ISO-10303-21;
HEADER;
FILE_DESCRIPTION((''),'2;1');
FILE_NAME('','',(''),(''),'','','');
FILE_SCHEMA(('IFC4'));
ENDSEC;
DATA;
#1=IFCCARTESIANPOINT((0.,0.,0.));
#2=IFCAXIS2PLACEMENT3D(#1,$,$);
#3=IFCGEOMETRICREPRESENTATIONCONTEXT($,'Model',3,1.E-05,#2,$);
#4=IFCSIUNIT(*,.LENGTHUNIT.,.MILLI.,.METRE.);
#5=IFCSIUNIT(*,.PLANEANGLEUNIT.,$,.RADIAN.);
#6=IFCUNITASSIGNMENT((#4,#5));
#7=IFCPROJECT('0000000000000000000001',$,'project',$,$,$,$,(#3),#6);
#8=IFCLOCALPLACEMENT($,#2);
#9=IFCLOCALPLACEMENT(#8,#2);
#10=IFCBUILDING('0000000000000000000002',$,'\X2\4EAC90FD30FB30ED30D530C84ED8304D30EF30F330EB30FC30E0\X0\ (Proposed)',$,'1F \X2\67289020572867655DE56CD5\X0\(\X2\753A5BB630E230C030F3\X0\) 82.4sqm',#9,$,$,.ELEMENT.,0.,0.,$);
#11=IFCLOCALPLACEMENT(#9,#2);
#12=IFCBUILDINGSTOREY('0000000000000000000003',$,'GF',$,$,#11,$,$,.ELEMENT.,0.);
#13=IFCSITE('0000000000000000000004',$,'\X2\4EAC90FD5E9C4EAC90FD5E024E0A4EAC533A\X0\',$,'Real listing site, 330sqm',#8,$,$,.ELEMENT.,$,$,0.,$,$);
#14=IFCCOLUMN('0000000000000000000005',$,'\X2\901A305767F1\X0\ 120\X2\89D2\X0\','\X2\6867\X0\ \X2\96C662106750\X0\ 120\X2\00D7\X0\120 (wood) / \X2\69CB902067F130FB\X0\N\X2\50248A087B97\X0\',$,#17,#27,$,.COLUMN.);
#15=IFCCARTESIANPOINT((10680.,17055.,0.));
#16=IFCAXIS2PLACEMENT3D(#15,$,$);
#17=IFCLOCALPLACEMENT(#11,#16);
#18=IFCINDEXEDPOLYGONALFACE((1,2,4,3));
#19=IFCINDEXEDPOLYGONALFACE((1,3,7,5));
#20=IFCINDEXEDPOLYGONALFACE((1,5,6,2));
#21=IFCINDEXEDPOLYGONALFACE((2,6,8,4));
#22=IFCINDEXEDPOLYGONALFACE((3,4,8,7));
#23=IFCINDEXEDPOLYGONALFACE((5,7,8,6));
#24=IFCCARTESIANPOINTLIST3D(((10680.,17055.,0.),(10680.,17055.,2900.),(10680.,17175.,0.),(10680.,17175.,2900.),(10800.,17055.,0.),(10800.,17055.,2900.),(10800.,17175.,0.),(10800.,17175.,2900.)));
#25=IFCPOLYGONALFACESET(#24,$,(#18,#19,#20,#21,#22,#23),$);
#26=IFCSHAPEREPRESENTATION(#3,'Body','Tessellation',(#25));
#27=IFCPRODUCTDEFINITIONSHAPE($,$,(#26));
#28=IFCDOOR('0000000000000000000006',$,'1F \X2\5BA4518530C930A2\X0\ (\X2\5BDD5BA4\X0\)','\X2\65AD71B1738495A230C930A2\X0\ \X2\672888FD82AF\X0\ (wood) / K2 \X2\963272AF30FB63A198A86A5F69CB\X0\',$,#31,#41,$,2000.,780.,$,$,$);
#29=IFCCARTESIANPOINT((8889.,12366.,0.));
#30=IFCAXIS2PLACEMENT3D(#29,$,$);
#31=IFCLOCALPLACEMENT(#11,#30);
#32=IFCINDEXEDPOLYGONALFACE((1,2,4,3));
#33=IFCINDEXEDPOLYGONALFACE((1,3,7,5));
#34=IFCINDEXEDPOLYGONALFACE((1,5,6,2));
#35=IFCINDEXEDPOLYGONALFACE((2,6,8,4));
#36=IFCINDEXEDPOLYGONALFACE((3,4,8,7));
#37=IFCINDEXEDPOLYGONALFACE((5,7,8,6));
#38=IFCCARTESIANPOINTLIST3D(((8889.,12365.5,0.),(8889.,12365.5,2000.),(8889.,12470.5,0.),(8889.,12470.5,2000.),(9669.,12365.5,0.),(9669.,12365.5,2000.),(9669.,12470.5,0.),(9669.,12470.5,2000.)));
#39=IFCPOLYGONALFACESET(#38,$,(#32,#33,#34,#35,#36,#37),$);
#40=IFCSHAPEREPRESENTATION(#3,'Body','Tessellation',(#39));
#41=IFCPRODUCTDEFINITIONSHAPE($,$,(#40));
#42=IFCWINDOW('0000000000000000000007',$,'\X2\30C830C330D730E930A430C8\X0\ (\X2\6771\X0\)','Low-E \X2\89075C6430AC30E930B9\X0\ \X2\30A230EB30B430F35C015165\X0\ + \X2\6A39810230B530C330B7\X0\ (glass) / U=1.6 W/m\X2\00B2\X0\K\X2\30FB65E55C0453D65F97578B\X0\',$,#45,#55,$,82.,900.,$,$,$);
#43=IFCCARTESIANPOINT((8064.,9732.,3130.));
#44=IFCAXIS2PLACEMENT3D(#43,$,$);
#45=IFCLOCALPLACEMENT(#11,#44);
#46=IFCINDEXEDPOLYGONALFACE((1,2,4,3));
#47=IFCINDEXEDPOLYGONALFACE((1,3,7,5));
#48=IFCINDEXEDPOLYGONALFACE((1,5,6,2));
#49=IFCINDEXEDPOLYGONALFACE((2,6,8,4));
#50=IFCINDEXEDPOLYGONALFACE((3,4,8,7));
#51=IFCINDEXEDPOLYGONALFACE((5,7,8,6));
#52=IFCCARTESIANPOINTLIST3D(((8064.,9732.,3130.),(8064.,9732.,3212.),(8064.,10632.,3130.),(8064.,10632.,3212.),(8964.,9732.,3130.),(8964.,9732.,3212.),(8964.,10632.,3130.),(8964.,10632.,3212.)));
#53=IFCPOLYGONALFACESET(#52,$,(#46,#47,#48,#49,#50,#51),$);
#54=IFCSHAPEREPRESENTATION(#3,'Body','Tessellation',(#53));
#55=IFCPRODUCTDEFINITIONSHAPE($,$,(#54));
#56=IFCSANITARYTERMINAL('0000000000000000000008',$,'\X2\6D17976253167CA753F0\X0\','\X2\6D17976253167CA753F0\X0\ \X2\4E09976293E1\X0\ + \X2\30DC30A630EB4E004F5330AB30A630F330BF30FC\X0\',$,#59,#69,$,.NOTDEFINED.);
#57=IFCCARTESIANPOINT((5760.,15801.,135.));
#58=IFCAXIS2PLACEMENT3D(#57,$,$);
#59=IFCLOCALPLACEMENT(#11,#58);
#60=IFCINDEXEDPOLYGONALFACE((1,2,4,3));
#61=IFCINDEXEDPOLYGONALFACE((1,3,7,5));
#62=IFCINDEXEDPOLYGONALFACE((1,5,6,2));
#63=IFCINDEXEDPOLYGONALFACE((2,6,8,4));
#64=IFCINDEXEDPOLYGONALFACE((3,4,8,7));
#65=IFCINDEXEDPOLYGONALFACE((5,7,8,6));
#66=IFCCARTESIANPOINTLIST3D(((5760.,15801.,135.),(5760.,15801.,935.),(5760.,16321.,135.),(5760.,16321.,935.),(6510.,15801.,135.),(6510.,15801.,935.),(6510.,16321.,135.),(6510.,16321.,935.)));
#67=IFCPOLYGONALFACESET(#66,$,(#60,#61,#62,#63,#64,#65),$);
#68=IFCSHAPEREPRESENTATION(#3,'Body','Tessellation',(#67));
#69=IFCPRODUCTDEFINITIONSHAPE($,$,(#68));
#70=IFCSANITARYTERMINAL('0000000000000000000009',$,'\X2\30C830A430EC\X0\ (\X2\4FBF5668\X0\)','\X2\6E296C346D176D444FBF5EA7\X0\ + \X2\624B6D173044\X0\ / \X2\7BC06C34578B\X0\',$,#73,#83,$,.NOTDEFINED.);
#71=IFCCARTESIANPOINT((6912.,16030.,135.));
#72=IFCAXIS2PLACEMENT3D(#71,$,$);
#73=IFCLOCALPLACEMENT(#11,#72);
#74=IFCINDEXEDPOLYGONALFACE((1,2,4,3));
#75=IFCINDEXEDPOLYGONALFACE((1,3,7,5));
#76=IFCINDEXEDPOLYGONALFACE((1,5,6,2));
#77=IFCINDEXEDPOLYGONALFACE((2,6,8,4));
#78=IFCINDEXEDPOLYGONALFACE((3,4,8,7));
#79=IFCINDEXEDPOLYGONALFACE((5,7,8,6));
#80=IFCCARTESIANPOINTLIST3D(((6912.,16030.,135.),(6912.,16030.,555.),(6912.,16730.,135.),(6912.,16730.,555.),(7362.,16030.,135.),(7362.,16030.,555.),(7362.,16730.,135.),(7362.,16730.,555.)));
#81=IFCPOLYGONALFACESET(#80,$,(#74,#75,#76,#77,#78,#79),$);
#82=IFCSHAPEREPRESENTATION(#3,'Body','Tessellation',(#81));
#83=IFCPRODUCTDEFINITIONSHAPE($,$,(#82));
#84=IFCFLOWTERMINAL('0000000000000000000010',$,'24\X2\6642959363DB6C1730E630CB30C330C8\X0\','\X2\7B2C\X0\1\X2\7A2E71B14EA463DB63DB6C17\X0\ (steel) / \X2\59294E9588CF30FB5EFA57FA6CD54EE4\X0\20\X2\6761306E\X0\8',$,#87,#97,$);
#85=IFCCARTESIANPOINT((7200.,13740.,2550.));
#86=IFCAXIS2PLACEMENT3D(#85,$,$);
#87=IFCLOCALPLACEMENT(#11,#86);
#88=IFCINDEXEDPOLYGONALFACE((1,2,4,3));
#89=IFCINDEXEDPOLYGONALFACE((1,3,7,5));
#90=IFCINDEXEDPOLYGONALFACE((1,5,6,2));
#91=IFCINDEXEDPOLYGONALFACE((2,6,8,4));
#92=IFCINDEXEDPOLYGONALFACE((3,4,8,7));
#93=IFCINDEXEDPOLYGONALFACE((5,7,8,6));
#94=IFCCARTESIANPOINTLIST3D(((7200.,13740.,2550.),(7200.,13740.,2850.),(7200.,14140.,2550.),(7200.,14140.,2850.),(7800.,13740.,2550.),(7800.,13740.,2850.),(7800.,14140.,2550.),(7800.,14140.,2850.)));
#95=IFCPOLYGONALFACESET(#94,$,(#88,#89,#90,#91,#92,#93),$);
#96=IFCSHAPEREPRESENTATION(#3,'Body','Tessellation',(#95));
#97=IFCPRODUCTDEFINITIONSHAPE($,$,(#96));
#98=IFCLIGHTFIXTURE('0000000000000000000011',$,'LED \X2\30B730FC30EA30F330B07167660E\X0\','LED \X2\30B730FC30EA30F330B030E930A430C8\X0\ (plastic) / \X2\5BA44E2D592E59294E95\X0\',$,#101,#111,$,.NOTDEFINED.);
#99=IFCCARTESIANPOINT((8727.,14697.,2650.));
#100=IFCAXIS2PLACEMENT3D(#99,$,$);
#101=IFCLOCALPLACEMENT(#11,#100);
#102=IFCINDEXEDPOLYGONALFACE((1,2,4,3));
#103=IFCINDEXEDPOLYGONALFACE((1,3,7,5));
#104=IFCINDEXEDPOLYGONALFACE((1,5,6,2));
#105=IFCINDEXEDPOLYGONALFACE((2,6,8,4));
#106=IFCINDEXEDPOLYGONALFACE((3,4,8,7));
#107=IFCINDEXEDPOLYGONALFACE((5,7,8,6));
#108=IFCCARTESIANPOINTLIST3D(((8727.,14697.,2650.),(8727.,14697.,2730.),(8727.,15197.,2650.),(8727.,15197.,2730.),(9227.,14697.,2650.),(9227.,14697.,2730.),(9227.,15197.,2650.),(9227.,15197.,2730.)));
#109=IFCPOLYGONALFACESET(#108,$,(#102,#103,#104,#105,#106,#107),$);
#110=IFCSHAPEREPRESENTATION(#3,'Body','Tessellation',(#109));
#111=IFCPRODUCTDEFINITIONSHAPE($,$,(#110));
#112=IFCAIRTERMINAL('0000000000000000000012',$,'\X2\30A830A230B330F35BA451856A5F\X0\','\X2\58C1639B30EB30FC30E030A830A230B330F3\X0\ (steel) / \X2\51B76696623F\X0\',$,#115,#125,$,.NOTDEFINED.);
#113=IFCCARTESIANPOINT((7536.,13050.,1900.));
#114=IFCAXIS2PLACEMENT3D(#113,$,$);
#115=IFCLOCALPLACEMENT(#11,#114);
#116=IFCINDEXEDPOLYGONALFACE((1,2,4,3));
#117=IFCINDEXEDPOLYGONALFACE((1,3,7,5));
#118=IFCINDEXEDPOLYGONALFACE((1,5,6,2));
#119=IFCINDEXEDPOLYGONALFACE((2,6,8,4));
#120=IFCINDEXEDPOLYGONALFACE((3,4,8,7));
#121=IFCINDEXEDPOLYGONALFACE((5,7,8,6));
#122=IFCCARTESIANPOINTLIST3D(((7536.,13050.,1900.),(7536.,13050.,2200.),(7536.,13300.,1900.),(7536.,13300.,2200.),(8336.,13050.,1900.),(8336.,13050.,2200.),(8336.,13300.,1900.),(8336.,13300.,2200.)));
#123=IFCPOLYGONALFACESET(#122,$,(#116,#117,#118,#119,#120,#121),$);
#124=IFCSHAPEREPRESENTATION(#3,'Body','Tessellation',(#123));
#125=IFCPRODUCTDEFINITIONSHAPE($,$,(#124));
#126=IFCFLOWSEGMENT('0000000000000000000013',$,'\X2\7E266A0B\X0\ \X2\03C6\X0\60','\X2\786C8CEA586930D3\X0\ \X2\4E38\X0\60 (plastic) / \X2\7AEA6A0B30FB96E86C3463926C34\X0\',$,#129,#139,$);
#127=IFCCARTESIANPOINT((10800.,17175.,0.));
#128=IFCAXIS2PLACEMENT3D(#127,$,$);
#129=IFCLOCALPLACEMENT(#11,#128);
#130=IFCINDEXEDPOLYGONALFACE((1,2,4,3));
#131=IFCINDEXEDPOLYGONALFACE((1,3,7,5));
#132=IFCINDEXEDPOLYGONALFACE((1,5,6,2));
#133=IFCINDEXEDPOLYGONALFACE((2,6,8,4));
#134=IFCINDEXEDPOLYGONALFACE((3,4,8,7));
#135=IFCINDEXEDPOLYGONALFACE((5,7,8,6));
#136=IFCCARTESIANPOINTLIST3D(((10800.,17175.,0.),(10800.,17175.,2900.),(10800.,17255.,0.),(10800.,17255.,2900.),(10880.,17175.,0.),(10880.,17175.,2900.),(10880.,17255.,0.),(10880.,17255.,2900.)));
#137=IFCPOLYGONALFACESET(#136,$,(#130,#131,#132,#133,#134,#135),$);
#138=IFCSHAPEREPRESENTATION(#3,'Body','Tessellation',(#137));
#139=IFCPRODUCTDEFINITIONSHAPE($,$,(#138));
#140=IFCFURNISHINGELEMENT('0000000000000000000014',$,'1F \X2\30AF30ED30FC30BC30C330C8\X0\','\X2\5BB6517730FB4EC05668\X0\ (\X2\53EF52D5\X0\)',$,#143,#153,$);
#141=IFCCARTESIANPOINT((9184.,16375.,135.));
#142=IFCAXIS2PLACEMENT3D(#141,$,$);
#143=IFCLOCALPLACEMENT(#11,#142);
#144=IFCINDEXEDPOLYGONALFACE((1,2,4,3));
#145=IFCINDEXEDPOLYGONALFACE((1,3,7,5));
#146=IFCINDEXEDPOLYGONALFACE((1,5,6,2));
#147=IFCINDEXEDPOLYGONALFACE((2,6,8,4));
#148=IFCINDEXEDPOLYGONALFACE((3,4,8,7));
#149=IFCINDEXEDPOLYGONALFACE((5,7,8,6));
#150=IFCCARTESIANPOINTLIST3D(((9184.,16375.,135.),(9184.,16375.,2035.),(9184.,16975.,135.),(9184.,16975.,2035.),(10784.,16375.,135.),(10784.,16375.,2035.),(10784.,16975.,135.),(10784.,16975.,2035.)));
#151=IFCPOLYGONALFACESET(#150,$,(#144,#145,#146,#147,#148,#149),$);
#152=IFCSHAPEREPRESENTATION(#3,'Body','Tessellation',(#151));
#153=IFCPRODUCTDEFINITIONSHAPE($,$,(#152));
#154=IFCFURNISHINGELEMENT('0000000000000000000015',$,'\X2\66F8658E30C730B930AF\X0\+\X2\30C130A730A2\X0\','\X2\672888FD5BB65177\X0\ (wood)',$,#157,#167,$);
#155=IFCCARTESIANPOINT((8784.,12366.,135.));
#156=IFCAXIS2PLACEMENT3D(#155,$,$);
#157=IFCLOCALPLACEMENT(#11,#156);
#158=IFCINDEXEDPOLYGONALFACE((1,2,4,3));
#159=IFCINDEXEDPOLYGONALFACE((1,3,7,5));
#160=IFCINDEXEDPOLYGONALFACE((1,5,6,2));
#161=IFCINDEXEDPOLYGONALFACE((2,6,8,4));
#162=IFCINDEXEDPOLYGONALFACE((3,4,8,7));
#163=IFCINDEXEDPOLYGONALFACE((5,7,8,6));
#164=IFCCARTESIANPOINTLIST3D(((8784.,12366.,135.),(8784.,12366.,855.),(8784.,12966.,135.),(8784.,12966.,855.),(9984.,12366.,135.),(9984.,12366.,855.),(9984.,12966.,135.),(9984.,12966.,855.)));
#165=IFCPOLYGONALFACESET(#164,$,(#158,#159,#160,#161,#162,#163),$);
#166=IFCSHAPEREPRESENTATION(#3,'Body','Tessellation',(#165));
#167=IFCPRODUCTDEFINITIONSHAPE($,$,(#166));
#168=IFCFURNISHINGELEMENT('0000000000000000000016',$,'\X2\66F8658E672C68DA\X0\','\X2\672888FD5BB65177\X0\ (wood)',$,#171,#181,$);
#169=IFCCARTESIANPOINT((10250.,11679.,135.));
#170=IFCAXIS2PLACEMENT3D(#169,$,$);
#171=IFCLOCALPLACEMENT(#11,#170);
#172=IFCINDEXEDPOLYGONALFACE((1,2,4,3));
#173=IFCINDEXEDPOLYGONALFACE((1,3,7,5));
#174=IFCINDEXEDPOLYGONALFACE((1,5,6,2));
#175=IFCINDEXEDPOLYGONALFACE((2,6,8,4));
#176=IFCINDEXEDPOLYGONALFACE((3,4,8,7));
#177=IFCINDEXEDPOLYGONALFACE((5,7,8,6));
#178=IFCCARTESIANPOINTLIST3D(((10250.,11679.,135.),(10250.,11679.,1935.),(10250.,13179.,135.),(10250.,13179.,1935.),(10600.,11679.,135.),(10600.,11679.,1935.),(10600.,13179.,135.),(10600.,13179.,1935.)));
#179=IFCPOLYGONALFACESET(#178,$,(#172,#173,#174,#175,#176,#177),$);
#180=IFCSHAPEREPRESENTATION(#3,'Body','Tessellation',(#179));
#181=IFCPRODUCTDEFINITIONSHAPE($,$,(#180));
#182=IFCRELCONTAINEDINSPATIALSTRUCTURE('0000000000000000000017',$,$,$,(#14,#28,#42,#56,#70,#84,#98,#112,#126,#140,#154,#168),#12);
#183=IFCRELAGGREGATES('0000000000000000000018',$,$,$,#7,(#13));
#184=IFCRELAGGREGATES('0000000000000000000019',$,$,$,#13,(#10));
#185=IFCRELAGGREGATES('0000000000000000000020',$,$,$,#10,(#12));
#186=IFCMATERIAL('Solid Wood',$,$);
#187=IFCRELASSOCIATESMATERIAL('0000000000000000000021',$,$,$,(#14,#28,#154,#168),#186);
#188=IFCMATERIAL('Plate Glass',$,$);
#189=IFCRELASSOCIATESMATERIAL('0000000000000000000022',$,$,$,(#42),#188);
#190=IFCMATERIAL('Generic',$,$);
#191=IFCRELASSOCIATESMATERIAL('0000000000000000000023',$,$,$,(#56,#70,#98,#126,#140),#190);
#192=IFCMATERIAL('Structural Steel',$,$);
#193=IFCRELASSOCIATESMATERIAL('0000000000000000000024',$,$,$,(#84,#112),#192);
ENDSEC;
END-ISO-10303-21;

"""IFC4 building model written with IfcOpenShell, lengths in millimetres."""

from ifc_helpers import new_model, si_unit, frame, frame_2d, origin, place, context, project, spatial, rectangle, extrude, material, element, save


model = new_model("IFC4")

# Units and contexts
model_context = context("Model", 3, precision=1e-05, world=origin())
ifc_project = project(units=[si_unit("LENGTHUNIT", "METRE", prefix="MILLI"), si_unit("PLANEANGLEUNIT", "RADIAN")], contexts=[model_context])

# Site, building, storey
site_placement = place(None, origin())
site = spatial("IfcSite", under=ifc_project, at=site_placement, Name="京都府京都市上京区", ObjectType="Real listing site, 330sqm", CompositionType="ELEMENT", RefElevation=0.0)
building_placement = place(site_placement, origin())
building = spatial("IfcBuilding", under=site, at=building_placement, Name="京都・ロフト付きワンルーム (Proposed)", ObjectType="1F 木造在来工法(町家モダン) 82.4sqm", CompositionType="ELEMENT", ElevationOfRefHeight=0.0, ElevationOfTerrain=0.0)
storey_placement = place(building_placement, origin())
storey = spatial("IfcBuildingStorey", under=building, at=storey_placement, Name="GF", CompositionType="ELEMENT", Elevation=0.0)

# Column
ifc_material_1 = material(Name="Solid Wood")
column_1_placement = place(storey_placement, frame((10680.0, 17055.0, 0.0)))
element("IfcColumn", 1, at=column_1_placement, inside=storey, material=ifc_material_1, Name="通し柱 120角", Description="桧 集成材 120×120 (wood) / 構造柱・N値計算", PredefinedType="COLUMN", context=model_context, shape_type="SweptSolid", body=[
    extrude(rectangle(XDim=120.0, YDim=120.0, at=frame_2d((60.0, 60.0))), frame((10680.0, 17055.0, 0.0)), (0.0, 0.0, 1.0), 2900.0),
])

# Door
door_placement = place(storey_placement, frame((8889.0, 12366.0, 0.0)))
element("IfcDoor", 2, at=door_placement, inside=storey, material=ifc_material_1, Name="1F 室内ドア (寝室)", Description="断熱玄関ドア 木製芯 (wood) / K2 防犯・採風機構", OverallHeight=2000.0, OverallWidth=780.0, context=model_context, shape_type="SweptSolid", body=[
    extrude(rectangle(XDim=780.0, YDim=105.0, at=frame_2d((390.0, 52.0))), frame((8889.0, 12366.0, 0.0)), (0.0, 0.0, 1.0), 2000.0),
])

# Window
ifc_material_2 = material(Name="Plate Glass")
window_placement = place(storey_placement, frame((8064.0, 9732.0, 3130.0)))
element("IfcWindow", 3, at=window_placement, inside=storey, material=ifc_material_2, Name="トップライト (東)", Description="Low-E 複層ガラス アルゴン封入 + 樹脂サッシ (glass) / U=1.6 W/m²K・日射取得型", OverallHeight=82.0, OverallWidth=900.0, context=model_context, shape_type="SweptSolid", body=[
    extrude(rectangle(XDim=900.0, YDim=900.0, at=frame_2d((450.0, 450.0))), frame((8064.0, 9732.0, 3130.0)), (0.0, 0.0, 1.0), 82.0),
])

# Sanitary terminals
ifc_material_3 = material(Name="Generic")
sanitary_terminal_1_placement = place(storey_placement, frame((5760.0, 15801.0, 135.0)))
element("IfcSanitaryTerminal", 4, at=sanitary_terminal_1_placement, inside=storey, material=ifc_material_3, Name="洗面化粧台", Description="洗面化粧台 三面鏡 + ボウル一体カウンター", PredefinedType="NOTDEFINED", context=model_context, shape_type="SweptSolid", body=[
    extrude(rectangle(XDim=750.0, YDim=520.0, at=frame_2d((375.0, 260.0))), frame((5760.0, 15801.0, 135.0)), (0.0, 0.0, 1.0), 800.0),
])
sanitary_terminal_2_placement = place(storey_placement, frame((6912.0, 16030.0, 135.0)))
element("IfcSanitaryTerminal", 5, at=sanitary_terminal_2_placement, inside=storey, material=ifc_material_3, Name="トイレ (便器)", Description="温水洗浄便座 + 手洗い / 節水型", PredefinedType="NOTDEFINED", context=model_context, shape_type="SweptSolid", body=[
    extrude(rectangle(XDim=450.0, YDim=700.0, at=frame_2d((225.0, 350.0))), frame((6912.0, 16030.0, 135.0)), (0.0, 0.0, 1.0), 420.0),
])

# Flow terminal
ifc_material_4 = material(Name="Structural Steel")
flow_terminal_placement = place(storey_placement, frame((7200.0, 13740.0, 2550.0)))
element("IfcFlowTerminal", 6, at=flow_terminal_placement, inside=storey, material=ifc_material_4, Name="24時間換気ユニット", Description="第1種熱交換換気 (steel) / 天井裏・建基法令20条の8", context=model_context, shape_type="SweptSolid", body=[
    extrude(rectangle(XDim=600.0, YDim=400.0, at=frame_2d((300.0, 200.0))), frame((7200.0, 13740.0, 2550.0)), (0.0, 0.0, 1.0), 300.0),
])

# Light fixture
light_fixture_placement = place(storey_placement, frame((8727.0, 14697.0, 2650.0)))
element("IfcLightFixture", 7, at=light_fixture_placement, inside=storey, material=ifc_material_3, Name="LED シーリング照明", Description="LED シーリングライト (plastic) / 室中央天井", PredefinedType="NOTDEFINED", context=model_context, shape_type="SweptSolid", body=[
    extrude(rectangle(XDim=500.0, YDim=500.0, at=frame_2d((250.0, 250.0))), frame((8727.0, 14697.0, 2650.0)), (0.0, 0.0, 1.0), 80.0),
])

# Air terminal
air_terminal_placement = place(storey_placement, frame((7536.0, 13050.0, 1900.0)))
element("IfcAirTerminal", 8, at=air_terminal_placement, inside=storey, material=ifc_material_4, Name="エアコン室内機", Description="壁掛ルームエアコン (steel) / 冷暖房", PredefinedType="NOTDEFINED", context=model_context, shape_type="SweptSolid", body=[
    extrude(rectangle(XDim=800.0, YDim=250.0, at=frame_2d((400.0, 125.0))), frame((7536.0, 13050.0, 1900.0)), (0.0, 0.0, 1.0), 300.0),
])

# Flow segment
flow_segment_placement = place(storey_placement, frame((10800.0, 17175.0, 0.0)))
element("IfcFlowSegment", 9, at=flow_segment_placement, inside=storey, material=ifc_material_3, Name="縦樋 φ60", Description="硬質塩ビ 丸60 (plastic) / 竪樋・雨水排水", context=model_context, shape_type="SweptSolid", body=[
    extrude(rectangle(XDim=80.0, YDim=80.0, at=frame_2d((40.0, 40.0))), frame((10800.0, 17175.0, 0.0)), (0.0, 0.0, 1.0), 2900.0),
])

# Furnishing elements
furnishing_1_placement = place(storey_placement, frame((9184.0, 16375.0, 135.0)))
element("IfcFurnishingElement", 10, at=furnishing_1_placement, inside=storey, material=ifc_material_3, Name="1F クローゼット", Description="家具・什器 (可動)", context=model_context, shape_type="SweptSolid", body=[
    extrude(rectangle(XDim=1600.0, YDim=600.0, at=frame_2d((800.0, 300.0))), frame((9184.0, 16375.0, 135.0)), (0.0, 0.0, 1.0), 1900.0),
])
furnishing_2_placement = place(storey_placement, frame((8784.0, 12366.0, 135.0)))
element("IfcFurnishingElement", 11, at=furnishing_2_placement, inside=storey, material=ifc_material_1, Name="書斎デスク+チェア", Description="木製家具 (wood)", context=model_context, shape_type="SweptSolid", body=[
    extrude(rectangle(XDim=1200.0, YDim=600.0, at=frame_2d((600.0, 300.0))), frame((8784.0, 12366.0, 135.0)), (0.0, 0.0, 1.0), 720.0),
])
furnishing_3_placement = place(storey_placement, frame((10250.0, 11679.0, 135.0)))
element("IfcFurnishingElement", 12, at=furnishing_3_placement, inside=storey, material=ifc_material_1, Name="書斎本棚", Description="木製家具 (wood)", context=model_context, shape_type="SweptSolid", body=[
    extrude(rectangle(XDim=350.0, YDim=1500.0, at=frame_2d((175.0, 750.0))), frame((10250.0, 11679.0, 135.0)), (0.0, 0.0, 1.0), 1800.0),
])

save(model, "model.ifc")
